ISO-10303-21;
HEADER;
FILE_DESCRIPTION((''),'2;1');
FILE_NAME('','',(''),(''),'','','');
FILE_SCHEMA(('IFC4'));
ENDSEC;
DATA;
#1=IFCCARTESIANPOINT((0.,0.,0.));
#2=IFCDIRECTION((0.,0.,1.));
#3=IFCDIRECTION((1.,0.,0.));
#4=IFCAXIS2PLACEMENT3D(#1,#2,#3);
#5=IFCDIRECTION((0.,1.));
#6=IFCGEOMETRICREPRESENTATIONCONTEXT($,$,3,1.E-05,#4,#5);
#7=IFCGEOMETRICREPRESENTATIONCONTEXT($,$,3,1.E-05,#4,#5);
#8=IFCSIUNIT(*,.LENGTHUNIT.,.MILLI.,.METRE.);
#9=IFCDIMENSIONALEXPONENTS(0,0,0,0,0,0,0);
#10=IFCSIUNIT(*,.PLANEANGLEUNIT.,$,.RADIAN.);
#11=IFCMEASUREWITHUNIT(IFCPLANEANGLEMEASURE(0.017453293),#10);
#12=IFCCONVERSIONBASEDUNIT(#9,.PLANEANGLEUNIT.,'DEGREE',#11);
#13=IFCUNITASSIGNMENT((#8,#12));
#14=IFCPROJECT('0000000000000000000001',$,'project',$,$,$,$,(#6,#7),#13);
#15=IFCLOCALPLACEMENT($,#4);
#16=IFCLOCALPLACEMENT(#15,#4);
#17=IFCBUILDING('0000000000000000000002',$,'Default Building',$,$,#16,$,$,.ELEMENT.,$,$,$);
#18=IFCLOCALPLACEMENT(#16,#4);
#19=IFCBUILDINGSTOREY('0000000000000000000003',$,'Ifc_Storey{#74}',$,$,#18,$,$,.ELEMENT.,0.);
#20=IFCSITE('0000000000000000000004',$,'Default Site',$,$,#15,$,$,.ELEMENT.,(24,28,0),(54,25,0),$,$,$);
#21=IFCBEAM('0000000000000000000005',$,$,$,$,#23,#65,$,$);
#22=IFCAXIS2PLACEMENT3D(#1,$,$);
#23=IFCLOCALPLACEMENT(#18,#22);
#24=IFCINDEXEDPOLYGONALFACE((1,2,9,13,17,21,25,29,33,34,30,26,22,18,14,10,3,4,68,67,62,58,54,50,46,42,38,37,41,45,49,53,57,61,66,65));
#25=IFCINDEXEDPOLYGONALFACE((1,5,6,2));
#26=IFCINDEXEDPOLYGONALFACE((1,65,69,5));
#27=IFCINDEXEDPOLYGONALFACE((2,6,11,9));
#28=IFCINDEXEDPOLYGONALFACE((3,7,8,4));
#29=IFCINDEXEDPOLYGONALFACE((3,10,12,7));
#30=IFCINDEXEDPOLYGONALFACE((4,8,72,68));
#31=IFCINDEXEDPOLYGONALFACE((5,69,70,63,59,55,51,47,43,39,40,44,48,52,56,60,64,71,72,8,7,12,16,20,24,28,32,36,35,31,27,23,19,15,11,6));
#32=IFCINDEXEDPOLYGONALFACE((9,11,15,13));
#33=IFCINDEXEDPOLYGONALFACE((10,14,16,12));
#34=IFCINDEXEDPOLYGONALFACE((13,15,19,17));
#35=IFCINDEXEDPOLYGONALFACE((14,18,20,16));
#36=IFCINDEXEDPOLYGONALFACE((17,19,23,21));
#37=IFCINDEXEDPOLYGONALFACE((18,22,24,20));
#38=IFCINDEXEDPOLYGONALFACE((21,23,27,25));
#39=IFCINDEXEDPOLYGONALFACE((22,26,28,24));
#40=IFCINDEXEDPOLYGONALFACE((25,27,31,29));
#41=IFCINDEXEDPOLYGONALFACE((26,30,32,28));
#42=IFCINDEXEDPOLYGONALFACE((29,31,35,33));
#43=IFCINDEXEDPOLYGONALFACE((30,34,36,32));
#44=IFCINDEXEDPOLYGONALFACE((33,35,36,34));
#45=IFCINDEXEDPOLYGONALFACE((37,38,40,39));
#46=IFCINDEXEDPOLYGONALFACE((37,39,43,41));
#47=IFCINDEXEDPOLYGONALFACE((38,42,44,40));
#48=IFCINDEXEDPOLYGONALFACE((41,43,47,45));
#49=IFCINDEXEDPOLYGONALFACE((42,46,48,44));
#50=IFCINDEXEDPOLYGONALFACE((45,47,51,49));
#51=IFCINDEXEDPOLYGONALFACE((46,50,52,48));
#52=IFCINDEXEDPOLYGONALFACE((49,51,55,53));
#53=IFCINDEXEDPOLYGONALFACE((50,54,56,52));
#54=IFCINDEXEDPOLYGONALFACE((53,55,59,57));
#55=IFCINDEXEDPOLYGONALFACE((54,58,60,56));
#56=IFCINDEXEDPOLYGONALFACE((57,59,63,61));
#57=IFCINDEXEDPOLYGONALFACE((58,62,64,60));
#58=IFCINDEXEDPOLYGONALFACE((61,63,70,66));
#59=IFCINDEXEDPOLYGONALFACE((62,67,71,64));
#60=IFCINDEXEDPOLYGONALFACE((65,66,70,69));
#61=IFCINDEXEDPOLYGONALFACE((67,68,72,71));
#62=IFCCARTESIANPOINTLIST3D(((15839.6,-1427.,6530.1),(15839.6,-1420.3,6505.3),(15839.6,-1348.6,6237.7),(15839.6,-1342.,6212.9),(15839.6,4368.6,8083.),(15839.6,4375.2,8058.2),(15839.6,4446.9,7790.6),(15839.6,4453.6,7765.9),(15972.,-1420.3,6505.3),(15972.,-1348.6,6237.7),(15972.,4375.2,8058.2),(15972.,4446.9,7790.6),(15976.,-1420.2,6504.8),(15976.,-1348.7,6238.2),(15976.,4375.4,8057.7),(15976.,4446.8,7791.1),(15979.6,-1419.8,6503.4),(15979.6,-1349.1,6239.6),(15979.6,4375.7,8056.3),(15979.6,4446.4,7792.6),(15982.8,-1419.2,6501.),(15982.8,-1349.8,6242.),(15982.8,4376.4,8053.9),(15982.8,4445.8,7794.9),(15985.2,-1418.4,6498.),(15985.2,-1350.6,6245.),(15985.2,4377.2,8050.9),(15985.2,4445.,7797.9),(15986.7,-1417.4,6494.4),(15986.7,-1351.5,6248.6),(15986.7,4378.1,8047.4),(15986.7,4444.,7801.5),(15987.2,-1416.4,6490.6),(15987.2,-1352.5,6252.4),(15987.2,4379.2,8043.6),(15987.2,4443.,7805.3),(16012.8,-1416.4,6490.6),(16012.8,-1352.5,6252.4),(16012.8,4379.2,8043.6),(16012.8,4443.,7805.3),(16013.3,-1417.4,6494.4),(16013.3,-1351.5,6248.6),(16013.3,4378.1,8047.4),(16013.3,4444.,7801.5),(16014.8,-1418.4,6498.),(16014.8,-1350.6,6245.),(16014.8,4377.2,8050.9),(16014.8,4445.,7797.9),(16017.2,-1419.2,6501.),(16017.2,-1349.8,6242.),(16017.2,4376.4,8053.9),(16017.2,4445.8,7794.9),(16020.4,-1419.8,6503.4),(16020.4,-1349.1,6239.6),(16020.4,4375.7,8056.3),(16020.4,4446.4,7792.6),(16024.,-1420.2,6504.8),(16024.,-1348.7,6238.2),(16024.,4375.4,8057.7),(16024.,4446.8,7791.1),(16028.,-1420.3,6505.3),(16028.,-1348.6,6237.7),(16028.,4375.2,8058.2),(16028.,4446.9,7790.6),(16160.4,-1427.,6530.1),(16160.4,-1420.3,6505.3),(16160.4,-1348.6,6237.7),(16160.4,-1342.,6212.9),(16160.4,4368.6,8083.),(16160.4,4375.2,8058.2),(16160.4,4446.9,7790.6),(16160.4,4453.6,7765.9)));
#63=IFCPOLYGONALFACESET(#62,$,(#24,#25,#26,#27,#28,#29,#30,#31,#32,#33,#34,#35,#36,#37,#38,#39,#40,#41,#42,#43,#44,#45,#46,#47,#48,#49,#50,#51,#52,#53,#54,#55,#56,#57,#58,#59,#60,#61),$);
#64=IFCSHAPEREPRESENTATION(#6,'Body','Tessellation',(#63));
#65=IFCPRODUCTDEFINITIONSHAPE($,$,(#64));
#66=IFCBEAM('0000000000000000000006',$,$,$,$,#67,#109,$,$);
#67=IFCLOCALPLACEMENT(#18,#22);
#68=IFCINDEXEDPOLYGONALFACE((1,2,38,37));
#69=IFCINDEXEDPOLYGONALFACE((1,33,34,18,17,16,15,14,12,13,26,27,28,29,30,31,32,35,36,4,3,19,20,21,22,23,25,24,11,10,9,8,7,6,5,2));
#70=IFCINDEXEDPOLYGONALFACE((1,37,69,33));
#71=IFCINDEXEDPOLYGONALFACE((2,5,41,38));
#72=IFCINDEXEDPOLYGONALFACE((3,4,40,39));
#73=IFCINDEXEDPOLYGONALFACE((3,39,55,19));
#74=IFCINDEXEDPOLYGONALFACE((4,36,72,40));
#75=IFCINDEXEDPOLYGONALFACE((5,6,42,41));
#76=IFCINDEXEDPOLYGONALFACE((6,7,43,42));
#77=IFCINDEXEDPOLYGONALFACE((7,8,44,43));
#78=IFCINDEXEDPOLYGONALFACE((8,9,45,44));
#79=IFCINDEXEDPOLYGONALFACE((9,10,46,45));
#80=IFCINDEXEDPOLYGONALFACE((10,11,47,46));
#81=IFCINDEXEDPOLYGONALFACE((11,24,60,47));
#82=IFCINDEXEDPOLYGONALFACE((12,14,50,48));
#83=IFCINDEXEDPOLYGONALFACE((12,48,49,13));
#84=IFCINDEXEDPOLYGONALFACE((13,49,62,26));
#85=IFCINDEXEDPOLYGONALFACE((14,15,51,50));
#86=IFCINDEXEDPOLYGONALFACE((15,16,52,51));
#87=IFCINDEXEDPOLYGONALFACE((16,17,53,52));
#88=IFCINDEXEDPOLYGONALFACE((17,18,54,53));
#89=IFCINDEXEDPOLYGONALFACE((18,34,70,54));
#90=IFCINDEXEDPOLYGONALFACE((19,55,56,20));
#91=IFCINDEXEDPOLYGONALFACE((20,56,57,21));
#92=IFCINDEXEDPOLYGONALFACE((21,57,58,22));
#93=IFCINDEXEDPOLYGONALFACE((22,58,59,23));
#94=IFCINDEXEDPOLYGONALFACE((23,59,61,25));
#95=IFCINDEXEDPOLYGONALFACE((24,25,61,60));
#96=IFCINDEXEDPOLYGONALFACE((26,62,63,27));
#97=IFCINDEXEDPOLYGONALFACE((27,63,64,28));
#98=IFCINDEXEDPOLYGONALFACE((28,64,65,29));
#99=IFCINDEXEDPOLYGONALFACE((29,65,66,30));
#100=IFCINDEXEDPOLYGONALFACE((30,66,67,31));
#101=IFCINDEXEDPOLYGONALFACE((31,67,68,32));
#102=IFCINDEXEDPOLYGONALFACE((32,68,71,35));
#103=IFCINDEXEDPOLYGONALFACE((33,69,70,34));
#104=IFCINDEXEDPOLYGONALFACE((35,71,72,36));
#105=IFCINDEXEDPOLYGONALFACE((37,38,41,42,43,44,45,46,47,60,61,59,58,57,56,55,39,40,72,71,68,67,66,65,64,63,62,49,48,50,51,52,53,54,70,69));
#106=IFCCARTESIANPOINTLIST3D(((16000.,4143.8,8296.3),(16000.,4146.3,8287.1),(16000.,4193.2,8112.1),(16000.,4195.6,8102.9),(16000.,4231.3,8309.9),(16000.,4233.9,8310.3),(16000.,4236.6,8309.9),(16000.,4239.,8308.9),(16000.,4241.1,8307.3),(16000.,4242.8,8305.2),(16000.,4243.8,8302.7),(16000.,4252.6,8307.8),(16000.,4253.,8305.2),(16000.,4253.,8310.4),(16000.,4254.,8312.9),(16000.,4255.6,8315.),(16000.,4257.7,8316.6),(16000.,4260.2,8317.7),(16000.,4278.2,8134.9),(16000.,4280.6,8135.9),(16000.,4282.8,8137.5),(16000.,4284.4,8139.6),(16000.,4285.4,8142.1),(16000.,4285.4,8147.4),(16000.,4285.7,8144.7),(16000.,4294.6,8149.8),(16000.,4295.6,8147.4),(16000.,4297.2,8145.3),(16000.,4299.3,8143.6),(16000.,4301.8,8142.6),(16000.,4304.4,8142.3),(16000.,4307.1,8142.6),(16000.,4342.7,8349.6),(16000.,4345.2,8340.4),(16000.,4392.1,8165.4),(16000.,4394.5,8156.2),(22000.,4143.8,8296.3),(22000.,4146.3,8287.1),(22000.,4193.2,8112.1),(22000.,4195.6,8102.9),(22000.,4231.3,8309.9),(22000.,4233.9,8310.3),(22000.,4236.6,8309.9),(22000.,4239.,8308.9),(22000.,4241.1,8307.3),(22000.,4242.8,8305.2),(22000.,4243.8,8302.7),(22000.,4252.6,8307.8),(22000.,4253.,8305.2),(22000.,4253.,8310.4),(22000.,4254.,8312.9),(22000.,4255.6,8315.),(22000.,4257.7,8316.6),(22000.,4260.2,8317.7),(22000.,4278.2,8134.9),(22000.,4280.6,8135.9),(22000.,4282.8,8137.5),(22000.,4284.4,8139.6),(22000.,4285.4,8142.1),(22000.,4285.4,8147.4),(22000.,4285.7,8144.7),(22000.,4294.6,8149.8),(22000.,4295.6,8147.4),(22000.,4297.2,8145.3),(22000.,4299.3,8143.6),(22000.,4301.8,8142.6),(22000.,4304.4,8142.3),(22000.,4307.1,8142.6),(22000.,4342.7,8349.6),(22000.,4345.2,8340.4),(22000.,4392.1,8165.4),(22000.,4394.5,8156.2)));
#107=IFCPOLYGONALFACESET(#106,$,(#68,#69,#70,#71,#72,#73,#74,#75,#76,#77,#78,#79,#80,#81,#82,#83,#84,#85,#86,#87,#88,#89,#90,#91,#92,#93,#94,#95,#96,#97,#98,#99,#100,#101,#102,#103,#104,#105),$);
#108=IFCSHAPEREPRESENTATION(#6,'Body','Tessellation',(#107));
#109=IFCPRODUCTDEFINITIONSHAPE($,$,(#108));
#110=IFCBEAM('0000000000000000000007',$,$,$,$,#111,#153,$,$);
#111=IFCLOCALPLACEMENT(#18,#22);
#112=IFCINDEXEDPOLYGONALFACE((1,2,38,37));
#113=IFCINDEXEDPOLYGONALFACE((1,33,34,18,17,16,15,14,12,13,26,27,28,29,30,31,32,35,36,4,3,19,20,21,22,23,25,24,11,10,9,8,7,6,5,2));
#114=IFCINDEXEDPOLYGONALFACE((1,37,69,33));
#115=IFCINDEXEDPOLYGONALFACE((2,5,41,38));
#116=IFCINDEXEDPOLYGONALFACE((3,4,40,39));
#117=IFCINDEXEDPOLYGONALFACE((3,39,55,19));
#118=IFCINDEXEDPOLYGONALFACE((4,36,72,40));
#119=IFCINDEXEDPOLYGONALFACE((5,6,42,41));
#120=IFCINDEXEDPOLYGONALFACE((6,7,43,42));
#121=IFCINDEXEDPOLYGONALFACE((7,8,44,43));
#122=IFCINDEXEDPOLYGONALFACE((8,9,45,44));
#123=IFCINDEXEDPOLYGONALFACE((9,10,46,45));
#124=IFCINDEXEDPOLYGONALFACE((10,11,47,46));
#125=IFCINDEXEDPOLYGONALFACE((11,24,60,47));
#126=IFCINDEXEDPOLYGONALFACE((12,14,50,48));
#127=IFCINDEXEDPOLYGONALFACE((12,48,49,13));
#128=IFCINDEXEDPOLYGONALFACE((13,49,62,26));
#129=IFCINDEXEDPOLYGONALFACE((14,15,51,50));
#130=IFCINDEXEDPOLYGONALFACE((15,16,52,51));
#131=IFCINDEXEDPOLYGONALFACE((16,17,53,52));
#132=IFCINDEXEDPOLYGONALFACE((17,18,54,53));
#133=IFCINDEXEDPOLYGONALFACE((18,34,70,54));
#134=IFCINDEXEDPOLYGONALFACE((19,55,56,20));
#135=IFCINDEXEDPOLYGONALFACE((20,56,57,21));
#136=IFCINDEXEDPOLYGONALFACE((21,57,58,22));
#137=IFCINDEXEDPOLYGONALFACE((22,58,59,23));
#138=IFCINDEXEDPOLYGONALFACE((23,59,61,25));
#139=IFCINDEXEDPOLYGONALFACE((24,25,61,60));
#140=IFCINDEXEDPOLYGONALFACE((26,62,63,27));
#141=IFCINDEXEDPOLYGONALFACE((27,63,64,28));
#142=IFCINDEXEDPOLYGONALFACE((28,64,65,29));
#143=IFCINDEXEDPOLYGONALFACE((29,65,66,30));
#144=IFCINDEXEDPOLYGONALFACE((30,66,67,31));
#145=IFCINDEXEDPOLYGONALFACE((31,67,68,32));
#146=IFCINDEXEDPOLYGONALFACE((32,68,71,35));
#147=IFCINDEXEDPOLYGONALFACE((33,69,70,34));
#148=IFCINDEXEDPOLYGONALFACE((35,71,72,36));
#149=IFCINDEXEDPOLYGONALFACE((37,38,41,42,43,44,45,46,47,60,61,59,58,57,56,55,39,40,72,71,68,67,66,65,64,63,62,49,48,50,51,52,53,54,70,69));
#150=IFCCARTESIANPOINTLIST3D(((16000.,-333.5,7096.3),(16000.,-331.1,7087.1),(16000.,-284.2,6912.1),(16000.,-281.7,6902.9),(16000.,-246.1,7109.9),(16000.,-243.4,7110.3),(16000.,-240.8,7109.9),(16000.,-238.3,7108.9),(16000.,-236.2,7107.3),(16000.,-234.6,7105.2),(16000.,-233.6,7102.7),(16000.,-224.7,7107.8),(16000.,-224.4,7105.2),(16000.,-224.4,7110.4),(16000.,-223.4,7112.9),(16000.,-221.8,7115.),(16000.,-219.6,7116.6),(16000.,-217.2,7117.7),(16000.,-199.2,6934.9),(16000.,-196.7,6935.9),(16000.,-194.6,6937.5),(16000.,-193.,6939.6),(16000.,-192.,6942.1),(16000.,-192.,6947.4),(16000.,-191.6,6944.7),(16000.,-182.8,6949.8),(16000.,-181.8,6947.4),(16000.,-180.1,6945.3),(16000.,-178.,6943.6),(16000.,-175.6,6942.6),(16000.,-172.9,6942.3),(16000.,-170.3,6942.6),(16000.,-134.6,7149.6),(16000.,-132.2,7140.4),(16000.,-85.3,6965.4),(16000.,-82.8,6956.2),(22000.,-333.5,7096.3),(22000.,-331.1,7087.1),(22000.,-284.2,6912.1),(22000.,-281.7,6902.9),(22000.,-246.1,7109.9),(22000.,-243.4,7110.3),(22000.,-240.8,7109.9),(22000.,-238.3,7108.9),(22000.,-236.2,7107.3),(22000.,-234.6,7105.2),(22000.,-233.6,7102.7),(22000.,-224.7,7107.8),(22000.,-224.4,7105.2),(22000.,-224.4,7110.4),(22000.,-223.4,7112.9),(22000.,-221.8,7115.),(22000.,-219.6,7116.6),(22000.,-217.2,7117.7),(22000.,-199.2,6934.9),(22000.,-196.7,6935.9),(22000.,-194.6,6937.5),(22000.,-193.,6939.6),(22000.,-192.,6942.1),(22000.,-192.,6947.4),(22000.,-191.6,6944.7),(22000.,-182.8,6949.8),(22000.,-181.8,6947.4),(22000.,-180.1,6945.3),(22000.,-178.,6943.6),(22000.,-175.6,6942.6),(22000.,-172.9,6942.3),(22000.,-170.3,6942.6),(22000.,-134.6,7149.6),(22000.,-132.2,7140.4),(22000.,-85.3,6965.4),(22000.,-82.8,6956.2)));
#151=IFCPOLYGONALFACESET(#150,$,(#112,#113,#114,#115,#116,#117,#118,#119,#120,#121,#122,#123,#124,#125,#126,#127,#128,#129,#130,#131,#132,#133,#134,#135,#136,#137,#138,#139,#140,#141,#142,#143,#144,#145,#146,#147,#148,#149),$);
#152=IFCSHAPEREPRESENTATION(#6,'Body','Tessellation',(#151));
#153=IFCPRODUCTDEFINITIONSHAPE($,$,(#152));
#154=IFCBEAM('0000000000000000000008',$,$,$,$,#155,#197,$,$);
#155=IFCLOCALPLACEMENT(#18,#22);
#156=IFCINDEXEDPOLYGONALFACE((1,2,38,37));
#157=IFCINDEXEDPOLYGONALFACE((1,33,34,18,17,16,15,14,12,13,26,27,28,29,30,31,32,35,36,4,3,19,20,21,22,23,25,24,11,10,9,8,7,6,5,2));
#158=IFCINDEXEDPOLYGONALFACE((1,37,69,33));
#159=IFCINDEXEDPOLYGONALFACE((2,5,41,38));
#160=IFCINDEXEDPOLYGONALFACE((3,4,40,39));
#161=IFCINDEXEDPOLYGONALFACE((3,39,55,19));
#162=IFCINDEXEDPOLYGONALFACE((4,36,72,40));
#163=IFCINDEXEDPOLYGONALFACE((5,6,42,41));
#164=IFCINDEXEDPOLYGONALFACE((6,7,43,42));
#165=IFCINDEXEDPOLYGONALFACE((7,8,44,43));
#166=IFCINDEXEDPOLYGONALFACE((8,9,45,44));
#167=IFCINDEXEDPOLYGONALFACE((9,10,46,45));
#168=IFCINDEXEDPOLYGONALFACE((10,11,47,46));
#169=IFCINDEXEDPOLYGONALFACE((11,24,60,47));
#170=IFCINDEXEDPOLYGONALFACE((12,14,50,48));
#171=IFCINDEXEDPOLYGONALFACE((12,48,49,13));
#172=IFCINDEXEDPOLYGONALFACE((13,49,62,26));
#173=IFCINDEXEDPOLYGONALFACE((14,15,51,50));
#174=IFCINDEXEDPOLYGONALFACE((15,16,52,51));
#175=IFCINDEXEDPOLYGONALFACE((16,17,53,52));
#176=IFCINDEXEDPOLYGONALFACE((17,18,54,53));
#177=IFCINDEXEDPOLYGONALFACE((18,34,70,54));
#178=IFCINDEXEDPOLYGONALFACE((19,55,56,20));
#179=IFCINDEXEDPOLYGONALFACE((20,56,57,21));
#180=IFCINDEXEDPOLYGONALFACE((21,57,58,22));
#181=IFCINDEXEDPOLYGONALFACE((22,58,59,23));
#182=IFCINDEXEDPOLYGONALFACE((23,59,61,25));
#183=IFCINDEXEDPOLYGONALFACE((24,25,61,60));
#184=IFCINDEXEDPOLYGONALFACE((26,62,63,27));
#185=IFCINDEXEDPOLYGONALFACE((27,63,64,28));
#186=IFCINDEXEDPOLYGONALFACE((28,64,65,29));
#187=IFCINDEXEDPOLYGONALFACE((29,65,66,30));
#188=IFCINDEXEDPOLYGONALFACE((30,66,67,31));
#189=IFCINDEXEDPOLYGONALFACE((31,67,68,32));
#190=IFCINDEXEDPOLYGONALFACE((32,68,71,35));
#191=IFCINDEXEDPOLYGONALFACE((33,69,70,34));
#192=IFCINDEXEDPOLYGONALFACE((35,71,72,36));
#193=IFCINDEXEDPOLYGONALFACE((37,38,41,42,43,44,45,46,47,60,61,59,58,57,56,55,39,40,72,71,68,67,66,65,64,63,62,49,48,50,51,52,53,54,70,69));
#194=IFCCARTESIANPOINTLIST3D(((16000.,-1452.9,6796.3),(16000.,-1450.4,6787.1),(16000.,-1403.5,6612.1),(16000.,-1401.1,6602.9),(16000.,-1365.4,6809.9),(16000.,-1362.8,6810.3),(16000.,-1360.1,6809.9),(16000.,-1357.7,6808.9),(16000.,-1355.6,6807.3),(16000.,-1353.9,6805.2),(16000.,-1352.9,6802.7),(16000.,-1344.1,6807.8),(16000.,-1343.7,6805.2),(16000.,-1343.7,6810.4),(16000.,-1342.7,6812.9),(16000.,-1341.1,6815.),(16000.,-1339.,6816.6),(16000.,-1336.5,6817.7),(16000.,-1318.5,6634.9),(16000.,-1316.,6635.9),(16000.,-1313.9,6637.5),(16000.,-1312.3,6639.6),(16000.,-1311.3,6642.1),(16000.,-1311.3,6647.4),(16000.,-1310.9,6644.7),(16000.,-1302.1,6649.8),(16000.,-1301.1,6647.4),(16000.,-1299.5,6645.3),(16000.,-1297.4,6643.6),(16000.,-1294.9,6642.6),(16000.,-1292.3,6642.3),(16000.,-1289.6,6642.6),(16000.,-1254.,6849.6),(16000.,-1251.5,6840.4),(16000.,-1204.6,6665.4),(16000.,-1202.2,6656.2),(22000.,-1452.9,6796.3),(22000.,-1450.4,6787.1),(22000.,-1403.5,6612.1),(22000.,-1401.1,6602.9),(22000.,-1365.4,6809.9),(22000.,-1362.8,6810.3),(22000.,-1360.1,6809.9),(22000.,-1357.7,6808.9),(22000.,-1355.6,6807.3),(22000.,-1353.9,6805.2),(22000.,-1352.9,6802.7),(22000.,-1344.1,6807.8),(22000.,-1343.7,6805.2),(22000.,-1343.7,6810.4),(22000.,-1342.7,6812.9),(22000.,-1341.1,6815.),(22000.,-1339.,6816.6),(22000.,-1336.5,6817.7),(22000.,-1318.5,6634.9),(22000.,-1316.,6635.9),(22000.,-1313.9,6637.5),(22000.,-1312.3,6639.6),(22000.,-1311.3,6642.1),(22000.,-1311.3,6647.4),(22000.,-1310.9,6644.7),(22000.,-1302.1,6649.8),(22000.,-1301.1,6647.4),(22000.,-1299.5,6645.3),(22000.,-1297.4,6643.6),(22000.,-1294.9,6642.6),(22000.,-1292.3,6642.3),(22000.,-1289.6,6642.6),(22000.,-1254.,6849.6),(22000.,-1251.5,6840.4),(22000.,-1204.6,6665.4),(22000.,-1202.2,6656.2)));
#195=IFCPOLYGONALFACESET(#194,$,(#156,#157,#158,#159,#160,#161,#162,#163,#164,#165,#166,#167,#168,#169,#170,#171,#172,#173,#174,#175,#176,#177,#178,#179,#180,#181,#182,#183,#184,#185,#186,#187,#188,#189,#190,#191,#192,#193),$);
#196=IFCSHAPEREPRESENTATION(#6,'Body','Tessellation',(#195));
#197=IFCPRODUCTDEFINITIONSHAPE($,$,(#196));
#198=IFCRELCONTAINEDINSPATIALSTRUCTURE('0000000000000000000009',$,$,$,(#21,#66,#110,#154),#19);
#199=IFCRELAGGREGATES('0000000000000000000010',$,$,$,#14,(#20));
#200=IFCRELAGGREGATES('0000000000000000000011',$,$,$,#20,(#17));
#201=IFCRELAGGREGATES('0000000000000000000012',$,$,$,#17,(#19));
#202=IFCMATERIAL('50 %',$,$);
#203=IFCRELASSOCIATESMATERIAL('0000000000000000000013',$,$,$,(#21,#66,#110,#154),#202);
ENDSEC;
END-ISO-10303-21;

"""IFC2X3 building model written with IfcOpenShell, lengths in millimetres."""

from ifc_helpers import new_model, entity, si_unit, converted_unit, direction, frame, origin_with_axes, origin_2d_with_axis, place, context, project, spatial, i_section, extrude, material, element, save


model = new_model("IFC2X3")

# Units and contexts
context_of_model_1 = context(None, 3, precision=1e-05, world=origin_with_axes(), true_north=direction((0.0, 1.0)))
context_of_model_2 = context(None, 3, precision=1e-05, world=origin_with_axes(), true_north=direction((0.0, 1.0)))
ifc_project = project(units=[si_unit("LENGTHUNIT", "METRE", prefix="MILLI"), converted_unit("PLANEANGLEUNIT", "DEGREE", entity("IfcPlaneAngleMeasure", 0.017453293), si_unit("PLANEANGLEUNIT", "RADIAN"), dimensions=[0, 0, 0, 0, 0, 0, 0])], contexts=[context_of_model_1, context_of_model_2])

# Site, building, storey
site_placement = place(None, origin_with_axes())
site = spatial("IfcSite", under=ifc_project, at=site_placement, Name="Default Site", CompositionType="ELEMENT", RefLatitude=(24, 28, 0), RefLongitude=(54, 25, 0))
building_placement = place(site_placement, origin_with_axes())
building = spatial("IfcBuilding", under=site, at=building_placement, Name="Default Building", CompositionType="ELEMENT")
storey_placement = place(building_placement, origin_with_axes())
storey = spatial("IfcBuildingStorey", under=building, at=storey_placement, Name="Ifc_Storey{#74}", CompositionType="ELEMENT", Elevation=0.0)

# Shared definitions
ifc_material_1 = material(Name="50 %")

# Beams
beam_1_placement = place(storey_placement, frame((16000.0, -1384.5, 6371.5), z_axis=(0.0, 0.0, 1.0), x_axis=(0.0, -1.0, 0.0)))
element("IfcBeam", 1, at=beam_1_placement, inside=storey, material=ifc_material_1, context=context_of_model_1, shape_type="SweptSolid", body=[
    extrude(i_section(OverallWidth=320.9, OverallDepth=328.3, WebThickness=25.5, FlangeThickness=25.6, FilletRadius=15.2, at=origin_2d_with_axis()), frame((0.0, 0.0, 0.0), z_axis=(-0.965926, 0.0, 0.258819), x_axis=(0.0, 1.0, 0.0)), (0.0, 0.0, 1.0), 6000.0),
])
for number, where, z_axis, x_axis in (
    (2, (16000.0, 4269.2, 8226.3), (0.0, -0.258819, 0.965926), (-1.0, 0.0, 0.0)),
    (3, (16000.0, -208.2, 7026.3), (0.0, -0.258819, 0.965926), (-1.0, 0.0, 0.0)),
    (4, (16000.0, -1327.5, 6726.3), (0.0, -0.258819, 0.965926), (-1.0, 0.0, 0.0)),
):
    element("IfcBeam", number, at=place(storey_placement, frame(where, z_axis=z_axis, x_axis=x_axis)), inside=storey, material=ifc_material_1, context=context_of_model_1, shape_type="SweptSolid", body=[
        extrude(i_section(OverallWidth=205.9, OverallDepth=200.2, WebThickness=9.5, FlangeThickness=9.5, FilletRadius=10.2, at=origin_2d_with_axis()), frame((0.0, 0.0, 0.0), z_axis=(-1.0, 0.0, 0.0), x_axis=(0.0, 1.0, 0.0)), (0.0, 0.0, 1.0), 6000.0),
    ])

save(model, "model.ifc")
